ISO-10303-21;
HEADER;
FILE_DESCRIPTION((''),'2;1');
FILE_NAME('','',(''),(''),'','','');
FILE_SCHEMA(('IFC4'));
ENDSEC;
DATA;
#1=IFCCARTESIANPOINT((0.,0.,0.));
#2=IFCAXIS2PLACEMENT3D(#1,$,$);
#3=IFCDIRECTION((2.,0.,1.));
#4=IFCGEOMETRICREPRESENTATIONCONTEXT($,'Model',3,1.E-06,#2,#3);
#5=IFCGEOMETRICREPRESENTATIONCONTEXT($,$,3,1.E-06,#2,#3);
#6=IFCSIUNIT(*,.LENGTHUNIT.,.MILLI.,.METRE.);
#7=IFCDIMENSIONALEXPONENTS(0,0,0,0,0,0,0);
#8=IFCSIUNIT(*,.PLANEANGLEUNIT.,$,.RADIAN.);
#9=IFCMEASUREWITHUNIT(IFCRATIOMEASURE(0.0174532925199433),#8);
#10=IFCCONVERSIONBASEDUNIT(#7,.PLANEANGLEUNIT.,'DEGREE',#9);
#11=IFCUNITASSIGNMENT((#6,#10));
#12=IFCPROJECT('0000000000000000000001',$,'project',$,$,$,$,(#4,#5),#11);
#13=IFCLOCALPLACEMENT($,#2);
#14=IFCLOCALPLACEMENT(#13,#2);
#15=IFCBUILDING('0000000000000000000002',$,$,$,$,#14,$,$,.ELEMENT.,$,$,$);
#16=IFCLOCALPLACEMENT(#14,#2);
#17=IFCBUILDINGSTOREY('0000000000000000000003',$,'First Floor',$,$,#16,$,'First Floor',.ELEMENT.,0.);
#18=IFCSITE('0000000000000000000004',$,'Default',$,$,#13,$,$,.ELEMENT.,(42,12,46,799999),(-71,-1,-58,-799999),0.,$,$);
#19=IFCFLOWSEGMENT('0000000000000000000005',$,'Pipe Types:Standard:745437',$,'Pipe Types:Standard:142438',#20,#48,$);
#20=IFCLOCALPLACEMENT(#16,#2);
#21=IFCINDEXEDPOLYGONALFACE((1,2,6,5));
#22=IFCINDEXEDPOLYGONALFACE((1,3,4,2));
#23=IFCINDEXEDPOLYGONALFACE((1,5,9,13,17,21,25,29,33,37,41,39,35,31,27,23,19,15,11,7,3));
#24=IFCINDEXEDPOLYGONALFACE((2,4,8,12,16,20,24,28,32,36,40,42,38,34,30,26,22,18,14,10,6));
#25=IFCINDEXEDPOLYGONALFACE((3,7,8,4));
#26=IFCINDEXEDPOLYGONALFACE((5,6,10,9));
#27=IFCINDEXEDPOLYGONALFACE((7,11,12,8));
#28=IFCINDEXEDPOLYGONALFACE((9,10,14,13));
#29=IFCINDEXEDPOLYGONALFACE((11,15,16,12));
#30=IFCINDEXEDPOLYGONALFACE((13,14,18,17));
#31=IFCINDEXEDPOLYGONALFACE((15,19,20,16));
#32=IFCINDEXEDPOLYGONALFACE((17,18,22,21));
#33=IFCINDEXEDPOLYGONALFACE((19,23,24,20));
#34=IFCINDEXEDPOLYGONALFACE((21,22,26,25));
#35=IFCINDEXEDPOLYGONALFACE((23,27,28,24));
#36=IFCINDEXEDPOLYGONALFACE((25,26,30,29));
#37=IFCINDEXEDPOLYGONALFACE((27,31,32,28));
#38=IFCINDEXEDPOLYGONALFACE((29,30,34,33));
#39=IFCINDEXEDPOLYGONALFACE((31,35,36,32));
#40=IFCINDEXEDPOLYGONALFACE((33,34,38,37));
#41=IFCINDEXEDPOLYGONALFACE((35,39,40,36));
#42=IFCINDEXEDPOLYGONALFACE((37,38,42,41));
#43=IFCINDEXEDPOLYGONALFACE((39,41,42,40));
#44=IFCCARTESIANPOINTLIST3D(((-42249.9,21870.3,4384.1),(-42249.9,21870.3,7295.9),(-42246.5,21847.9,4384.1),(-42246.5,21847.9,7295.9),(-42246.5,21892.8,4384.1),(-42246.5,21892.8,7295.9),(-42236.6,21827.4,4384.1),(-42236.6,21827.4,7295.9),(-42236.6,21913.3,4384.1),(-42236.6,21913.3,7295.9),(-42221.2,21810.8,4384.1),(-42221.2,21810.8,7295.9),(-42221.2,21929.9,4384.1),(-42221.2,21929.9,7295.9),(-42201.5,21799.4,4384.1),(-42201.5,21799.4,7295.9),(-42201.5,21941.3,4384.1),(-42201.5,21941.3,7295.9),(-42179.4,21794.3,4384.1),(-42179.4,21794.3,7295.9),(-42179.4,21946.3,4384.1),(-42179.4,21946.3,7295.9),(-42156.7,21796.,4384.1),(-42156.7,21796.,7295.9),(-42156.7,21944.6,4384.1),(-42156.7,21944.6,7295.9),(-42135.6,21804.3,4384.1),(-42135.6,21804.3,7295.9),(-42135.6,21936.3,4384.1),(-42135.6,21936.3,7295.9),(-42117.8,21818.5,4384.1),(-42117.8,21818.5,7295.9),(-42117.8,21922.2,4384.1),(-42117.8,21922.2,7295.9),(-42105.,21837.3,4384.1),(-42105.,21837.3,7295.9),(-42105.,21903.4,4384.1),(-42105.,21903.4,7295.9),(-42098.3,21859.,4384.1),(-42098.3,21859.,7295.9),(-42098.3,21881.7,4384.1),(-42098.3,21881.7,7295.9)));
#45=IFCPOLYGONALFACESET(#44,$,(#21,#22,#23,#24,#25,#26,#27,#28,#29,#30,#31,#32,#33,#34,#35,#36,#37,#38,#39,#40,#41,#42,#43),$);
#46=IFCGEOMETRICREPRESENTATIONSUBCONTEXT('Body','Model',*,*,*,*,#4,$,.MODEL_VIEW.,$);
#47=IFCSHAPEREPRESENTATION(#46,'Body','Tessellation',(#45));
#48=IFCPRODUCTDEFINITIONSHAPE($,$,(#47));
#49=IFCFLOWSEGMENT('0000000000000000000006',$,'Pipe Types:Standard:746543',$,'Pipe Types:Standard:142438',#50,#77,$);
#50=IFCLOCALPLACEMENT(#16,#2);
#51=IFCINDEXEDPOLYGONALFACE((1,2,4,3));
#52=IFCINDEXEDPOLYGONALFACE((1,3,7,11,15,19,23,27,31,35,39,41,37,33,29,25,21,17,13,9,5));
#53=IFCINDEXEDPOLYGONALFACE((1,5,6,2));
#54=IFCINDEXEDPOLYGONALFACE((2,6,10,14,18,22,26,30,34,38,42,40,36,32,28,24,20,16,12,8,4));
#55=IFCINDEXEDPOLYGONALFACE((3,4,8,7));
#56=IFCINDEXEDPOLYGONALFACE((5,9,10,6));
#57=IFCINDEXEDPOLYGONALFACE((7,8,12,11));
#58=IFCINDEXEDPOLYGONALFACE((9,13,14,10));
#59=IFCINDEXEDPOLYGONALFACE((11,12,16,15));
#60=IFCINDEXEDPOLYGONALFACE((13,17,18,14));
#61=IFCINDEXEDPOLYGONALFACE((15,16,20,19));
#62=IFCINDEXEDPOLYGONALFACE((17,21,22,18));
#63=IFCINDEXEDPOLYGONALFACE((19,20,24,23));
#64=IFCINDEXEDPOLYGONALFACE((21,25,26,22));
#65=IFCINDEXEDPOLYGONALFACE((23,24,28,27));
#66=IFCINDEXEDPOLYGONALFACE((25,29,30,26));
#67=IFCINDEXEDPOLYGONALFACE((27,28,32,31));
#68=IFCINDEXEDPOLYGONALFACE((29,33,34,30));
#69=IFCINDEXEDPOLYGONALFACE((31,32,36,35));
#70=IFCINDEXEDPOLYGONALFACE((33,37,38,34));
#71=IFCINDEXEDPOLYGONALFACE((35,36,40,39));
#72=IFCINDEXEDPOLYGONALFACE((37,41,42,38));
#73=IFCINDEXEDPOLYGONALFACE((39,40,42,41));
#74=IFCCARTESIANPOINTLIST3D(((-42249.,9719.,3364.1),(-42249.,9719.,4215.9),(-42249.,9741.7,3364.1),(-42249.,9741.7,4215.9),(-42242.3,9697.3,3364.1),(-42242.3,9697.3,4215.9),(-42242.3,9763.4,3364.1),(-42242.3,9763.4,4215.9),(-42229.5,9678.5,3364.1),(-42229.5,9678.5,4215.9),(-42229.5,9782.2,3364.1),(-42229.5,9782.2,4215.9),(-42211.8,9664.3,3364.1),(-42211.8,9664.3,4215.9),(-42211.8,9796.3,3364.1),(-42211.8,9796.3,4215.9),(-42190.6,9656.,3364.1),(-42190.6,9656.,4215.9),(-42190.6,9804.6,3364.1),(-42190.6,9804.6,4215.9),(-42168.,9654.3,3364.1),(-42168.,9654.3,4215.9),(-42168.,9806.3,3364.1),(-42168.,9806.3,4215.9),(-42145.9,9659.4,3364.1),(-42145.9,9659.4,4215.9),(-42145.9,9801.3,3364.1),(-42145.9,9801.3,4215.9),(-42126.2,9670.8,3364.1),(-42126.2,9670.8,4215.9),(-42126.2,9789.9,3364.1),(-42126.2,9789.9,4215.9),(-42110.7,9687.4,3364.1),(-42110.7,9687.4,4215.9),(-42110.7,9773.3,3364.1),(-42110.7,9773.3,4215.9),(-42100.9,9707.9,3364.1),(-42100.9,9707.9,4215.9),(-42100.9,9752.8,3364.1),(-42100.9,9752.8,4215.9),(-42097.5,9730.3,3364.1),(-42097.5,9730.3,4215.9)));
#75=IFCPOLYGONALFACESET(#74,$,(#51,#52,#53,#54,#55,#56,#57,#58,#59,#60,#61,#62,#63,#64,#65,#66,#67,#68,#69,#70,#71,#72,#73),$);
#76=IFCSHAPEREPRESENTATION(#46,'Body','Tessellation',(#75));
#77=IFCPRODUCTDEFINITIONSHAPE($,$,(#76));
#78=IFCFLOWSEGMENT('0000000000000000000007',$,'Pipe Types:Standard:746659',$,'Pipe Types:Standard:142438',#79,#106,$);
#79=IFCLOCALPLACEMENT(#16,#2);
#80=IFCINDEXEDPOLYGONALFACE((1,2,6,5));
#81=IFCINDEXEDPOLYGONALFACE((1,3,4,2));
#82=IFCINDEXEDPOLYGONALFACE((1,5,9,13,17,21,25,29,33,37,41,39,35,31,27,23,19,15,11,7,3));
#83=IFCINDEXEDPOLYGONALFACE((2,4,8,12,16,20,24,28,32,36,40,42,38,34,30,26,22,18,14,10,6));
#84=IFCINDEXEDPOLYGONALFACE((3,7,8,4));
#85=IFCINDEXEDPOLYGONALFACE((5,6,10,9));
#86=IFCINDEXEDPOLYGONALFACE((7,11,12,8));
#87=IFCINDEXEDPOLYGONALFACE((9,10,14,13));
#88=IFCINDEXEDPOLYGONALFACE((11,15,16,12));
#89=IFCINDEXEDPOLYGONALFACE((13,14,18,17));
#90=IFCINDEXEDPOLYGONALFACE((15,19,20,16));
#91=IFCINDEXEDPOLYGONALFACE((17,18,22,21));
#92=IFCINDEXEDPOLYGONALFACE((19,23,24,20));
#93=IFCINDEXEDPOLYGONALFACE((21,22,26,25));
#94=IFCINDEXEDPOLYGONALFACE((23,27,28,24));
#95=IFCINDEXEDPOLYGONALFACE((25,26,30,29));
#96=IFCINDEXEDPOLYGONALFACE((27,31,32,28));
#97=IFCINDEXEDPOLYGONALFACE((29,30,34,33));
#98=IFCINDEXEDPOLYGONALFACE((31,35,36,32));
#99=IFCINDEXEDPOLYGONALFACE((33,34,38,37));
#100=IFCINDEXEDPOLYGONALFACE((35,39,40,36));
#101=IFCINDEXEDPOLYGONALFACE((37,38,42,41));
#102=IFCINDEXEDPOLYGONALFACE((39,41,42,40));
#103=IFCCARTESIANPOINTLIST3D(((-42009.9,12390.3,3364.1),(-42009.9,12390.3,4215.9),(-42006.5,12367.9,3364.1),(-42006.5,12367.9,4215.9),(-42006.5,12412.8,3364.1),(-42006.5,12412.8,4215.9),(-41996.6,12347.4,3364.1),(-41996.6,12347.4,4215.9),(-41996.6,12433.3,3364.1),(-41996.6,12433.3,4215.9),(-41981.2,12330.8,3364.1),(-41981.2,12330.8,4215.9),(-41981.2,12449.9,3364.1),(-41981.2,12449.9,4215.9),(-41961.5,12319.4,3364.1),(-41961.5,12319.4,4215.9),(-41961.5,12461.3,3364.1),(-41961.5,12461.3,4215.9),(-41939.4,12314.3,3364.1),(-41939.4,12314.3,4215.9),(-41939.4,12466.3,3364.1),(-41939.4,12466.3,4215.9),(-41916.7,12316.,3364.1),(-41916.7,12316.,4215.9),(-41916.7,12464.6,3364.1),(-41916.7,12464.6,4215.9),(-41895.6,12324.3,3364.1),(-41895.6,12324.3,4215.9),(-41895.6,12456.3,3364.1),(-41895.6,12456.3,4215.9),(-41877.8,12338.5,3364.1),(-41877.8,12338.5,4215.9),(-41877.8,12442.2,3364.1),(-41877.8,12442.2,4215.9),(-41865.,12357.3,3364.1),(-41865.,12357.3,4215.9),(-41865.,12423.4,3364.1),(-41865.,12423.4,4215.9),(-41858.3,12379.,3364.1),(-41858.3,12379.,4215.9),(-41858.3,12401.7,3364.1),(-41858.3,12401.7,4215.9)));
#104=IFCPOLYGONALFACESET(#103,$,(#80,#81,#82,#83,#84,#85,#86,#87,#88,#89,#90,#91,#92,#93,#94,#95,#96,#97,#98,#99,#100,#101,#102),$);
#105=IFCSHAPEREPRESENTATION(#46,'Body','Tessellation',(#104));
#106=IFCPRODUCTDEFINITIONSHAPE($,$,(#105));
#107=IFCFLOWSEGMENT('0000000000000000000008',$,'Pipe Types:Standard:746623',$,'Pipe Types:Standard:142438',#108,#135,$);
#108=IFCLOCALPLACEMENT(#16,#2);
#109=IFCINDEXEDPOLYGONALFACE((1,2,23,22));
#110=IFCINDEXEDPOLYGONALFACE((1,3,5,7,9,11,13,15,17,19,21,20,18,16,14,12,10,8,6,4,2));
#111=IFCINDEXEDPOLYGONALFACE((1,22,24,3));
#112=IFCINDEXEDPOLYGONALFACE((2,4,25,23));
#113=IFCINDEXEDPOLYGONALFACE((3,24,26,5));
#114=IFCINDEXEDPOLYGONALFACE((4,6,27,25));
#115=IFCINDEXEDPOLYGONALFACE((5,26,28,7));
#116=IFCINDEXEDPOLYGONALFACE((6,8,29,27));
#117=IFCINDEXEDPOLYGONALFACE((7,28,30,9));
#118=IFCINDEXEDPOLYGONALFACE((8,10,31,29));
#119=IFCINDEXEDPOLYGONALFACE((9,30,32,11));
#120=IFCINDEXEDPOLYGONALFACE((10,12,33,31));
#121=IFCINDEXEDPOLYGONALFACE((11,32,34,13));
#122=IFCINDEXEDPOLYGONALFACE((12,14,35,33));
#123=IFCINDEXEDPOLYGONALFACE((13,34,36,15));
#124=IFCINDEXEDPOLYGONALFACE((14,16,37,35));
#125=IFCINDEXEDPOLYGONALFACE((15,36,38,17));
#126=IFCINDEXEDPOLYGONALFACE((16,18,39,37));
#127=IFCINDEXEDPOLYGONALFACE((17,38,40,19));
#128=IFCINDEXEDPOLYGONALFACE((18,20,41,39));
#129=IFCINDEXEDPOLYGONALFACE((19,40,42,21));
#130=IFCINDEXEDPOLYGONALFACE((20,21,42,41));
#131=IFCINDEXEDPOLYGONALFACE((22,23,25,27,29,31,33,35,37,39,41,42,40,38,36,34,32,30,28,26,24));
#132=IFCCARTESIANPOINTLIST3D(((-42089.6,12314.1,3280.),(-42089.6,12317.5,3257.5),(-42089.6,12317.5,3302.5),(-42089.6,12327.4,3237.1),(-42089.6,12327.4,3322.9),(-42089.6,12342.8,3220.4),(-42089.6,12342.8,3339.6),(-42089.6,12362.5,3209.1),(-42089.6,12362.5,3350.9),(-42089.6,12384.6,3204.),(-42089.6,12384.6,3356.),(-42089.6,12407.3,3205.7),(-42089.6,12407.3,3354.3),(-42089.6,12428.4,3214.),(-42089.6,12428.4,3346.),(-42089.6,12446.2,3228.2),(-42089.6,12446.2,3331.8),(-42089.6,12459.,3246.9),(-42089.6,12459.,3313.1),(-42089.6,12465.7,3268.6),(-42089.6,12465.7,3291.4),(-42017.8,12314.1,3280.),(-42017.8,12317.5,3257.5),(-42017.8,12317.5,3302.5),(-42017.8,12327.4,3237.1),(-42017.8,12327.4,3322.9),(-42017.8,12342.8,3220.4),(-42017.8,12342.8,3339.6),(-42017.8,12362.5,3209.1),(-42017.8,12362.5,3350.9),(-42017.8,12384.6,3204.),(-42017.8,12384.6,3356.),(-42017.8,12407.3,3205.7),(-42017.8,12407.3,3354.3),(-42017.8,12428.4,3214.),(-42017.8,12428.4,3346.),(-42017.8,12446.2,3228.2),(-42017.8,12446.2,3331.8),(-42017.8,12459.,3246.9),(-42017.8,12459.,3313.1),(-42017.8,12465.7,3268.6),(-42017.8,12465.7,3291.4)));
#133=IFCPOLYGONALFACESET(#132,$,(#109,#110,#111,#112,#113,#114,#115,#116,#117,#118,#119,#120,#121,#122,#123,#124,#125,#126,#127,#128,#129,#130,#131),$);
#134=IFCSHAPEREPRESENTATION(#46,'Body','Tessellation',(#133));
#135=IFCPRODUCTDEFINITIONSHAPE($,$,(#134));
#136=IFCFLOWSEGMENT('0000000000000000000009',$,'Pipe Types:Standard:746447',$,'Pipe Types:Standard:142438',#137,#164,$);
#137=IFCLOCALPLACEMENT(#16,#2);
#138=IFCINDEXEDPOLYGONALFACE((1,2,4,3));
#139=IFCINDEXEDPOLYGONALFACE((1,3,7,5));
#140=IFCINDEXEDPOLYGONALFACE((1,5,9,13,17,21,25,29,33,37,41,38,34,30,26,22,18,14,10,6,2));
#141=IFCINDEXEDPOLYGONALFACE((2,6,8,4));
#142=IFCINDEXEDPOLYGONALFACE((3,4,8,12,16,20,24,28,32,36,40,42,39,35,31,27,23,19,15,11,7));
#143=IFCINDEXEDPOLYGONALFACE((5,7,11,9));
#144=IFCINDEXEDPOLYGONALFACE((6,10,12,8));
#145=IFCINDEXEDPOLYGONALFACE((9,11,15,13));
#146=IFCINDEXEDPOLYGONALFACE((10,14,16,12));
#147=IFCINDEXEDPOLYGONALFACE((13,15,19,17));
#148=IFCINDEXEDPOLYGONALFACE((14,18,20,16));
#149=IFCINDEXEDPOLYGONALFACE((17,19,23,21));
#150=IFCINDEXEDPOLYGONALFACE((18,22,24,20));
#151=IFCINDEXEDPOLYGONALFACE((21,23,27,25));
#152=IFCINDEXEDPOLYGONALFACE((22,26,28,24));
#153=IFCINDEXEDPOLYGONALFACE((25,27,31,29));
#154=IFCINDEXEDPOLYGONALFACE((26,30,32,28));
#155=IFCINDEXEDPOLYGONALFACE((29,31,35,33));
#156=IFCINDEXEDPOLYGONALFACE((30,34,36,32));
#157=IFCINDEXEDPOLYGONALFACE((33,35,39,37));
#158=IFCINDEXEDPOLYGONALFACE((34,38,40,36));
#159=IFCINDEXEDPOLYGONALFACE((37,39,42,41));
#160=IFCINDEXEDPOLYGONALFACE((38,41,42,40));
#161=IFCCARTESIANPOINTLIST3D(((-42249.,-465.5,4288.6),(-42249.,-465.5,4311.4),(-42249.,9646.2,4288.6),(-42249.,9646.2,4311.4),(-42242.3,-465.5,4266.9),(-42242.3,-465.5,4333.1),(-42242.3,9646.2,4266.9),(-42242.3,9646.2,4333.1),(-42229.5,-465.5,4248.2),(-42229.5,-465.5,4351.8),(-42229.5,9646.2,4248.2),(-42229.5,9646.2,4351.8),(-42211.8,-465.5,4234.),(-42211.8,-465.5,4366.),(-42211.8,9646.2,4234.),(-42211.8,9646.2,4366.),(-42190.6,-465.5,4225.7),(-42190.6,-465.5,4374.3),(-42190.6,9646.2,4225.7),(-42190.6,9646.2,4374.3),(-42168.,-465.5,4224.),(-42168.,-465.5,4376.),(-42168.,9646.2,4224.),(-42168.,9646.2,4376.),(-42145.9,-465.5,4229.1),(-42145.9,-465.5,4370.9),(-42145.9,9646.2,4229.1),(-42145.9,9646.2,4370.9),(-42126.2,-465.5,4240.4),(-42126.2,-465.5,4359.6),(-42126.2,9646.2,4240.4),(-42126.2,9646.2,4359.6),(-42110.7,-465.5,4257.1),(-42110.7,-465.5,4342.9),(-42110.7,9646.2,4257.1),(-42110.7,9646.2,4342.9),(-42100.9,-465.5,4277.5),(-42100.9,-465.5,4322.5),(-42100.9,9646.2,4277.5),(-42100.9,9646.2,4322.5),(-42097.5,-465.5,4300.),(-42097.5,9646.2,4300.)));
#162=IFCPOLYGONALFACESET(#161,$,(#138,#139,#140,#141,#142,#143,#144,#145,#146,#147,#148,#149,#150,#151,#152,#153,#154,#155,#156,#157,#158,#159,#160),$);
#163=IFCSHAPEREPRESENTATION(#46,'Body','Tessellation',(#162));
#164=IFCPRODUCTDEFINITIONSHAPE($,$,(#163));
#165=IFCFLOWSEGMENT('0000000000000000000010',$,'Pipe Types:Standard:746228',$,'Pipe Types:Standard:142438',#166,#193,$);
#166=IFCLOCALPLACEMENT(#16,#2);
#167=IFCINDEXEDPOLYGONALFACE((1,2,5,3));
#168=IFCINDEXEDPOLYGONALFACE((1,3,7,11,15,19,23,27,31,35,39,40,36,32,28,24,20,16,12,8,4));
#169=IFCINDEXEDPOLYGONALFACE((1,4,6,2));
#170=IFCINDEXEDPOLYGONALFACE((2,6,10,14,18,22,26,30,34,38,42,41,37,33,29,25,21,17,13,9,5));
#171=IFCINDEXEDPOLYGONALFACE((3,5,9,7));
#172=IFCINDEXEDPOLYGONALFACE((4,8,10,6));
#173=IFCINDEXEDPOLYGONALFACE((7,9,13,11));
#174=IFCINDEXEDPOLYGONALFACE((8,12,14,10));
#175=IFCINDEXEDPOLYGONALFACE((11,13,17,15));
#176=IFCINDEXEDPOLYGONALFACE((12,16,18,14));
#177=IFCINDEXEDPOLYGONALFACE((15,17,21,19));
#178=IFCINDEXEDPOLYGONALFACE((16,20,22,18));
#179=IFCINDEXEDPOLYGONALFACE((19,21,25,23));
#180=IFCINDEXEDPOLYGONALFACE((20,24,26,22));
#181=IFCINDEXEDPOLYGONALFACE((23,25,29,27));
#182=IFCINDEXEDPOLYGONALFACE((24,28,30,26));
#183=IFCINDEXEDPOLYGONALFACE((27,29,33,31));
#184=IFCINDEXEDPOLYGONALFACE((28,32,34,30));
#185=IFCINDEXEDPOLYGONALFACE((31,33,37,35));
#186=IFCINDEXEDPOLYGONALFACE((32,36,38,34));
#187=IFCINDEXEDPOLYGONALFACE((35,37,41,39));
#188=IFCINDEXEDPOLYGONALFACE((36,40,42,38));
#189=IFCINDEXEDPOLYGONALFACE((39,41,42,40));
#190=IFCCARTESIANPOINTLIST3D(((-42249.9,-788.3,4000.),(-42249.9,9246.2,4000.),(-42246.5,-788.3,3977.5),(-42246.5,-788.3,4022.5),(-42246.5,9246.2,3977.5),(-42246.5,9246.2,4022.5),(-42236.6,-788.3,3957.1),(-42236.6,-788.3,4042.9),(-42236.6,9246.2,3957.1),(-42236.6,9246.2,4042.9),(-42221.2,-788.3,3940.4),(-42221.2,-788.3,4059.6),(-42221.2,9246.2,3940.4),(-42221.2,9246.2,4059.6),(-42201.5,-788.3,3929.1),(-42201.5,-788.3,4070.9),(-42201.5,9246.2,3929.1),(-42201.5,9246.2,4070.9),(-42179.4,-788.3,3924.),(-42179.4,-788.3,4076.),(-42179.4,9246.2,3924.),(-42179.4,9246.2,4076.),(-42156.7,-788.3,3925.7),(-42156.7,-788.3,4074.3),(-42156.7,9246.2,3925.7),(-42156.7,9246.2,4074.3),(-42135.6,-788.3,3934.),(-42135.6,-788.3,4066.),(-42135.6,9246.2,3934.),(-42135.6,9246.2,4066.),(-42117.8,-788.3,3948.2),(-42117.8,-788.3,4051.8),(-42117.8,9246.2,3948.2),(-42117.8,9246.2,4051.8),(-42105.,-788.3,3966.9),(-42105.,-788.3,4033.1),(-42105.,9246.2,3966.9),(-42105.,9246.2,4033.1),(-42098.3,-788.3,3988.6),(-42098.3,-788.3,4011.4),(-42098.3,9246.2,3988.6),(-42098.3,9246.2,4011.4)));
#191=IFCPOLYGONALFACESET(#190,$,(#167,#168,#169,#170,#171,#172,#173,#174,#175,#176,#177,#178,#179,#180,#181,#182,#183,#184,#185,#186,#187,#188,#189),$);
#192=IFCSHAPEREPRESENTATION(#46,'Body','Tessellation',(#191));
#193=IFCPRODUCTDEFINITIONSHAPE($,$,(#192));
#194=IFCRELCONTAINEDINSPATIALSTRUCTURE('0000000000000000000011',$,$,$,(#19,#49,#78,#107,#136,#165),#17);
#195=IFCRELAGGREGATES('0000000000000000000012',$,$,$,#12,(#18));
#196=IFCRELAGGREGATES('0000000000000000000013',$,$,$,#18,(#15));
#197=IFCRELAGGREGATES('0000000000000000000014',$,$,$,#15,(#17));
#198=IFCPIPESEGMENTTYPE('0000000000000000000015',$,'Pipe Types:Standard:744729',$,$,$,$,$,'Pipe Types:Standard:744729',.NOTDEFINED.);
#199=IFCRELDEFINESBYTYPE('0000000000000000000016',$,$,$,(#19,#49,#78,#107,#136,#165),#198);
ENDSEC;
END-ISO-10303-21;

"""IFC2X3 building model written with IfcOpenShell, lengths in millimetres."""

from ifc_helpers import new_model, entity, si_unit, converted_unit, direction, frame, frame_2d, origin, origin_2d_with_axis, place, context, subcontext, project, spatial, circle, extrude, type_object, element, save


model = new_model("IFC2X3")

# Units and contexts
model_context = context("Model", 3, precision=1e-06, world=origin(), true_north=direction((2.0, 0.0, 1.0)))
context_of_model = context(None, 3, precision=1e-06, world=origin(), true_north=direction((2.0, 0.0, 1.0)))
body_context = subcontext(model_context, "Body", "Model", "MODEL_VIEW")
ifc_project = project(units=[si_unit("LENGTHUNIT", "METRE", prefix="MILLI"), converted_unit("PLANEANGLEUNIT", "DEGREE", entity("IfcRatioMeasure", 0.0174532925199433), si_unit("PLANEANGLEUNIT", "RADIAN"), dimensions=[0, 0, 0, 0, 0, 0, 0])], contexts=[model_context, context_of_model])

# Site, building, storey
site_placement = place(None, origin())
site = spatial("IfcSite", under=ifc_project, at=site_placement, Name="Default", CompositionType="ELEMENT", RefLatitude=(42, 12, 46, 799999), RefLongitude=(-71, -1, -58, -799999), RefElevation=0.0)
building_placement = place(site_placement, origin())
building = spatial("IfcBuilding", under=site, at=building_placement, CompositionType="ELEMENT")
storey_placement = place(building_placement, origin())
storey = spatial("IfcBuildingStorey", under=building, at=storey_placement, Name="First Floor", LongName="First Floor", CompositionType="ELEMENT", Elevation=0.0)

# Flow segments
pipe_segment_type = type_object("IfcPipeSegmentType", Name="Pipe Types:Standard:744729", ElementType="Pipe Types:Standard:744729", PredefinedType="NOTDEFINED")
flow_segment_1_placement = place(storey_placement, origin())
element("IfcFlowSegment", 1, at=flow_segment_1_placement, inside=storey, type_object=pipe_segment_type, Name="Pipe Types:Standard:745437", ObjectType="Pipe Types:Standard:142438", context=body_context, shape_type="SweptSolid", body=[
    extrude(circle(Radius=76.2, at=origin_2d_with_axis()), frame((-42173.7, 21870.3, 4384.1), z_axis=(0.0, 0.0, 1.0), x_axis=(-1.0, 0.0, 0.0)), (0.0, 0.0, 1.0), 2911.7),
])
flow_segment_2_placement = place(storey_placement, origin())
element("IfcFlowSegment", 2, at=flow_segment_2_placement, inside=storey, type_object=pipe_segment_type, Name="Pipe Types:Standard:746543", ObjectType="Pipe Types:Standard:142438", context=body_context, shape_type="SweptSolid", body=[
    extrude(circle(Radius=76.2, at=frame_2d((0.0, 0.0), x_axis=(1.0, 0.0))), frame((-42173.7, 9730.3, 3364.1)), (0.0, 0.0, 1.0), 851.7),
])
flow_segment_3_placement = place(storey_placement, origin())
element("IfcFlowSegment", 3, at=flow_segment_3_placement, inside=storey, type_object=pipe_segment_type, Name="Pipe Types:Standard:746659", ObjectType="Pipe Types:Standard:142438", context=body_context, shape_type="SweptSolid", body=[
    extrude(circle(Radius=76.2, at=origin_2d_with_axis()), frame((-41933.7, 12390.3, 3364.1), z_axis=(0.0, 0.0, 1.0), x_axis=(-1.0, 0.0, 0.0)), (0.0, 0.0, 1.0), 851.7),
])
flow_segment_4_placement = place(storey_placement, origin())
element("IfcFlowSegment", 4, at=flow_segment_4_placement, inside=storey, type_object=pipe_segment_type, Name="Pipe Types:Standard:746623", ObjectType="Pipe Types:Standard:142438", context=body_context, shape_type="SweptSolid", body=[
    extrude(circle(Radius=76.2, at=origin_2d_with_axis()), frame((-42089.6, 12390.3, 3280.0), z_axis=(1.0, 0.0, 0.0), x_axis=(0.0, -1.0, 0.0)), (0.0, 0.0, 1.0), 71.7),
])
flow_segment_5_placement = place(storey_placement, origin())
element("IfcFlowSegment", 5, at=flow_segment_5_placement, inside=storey, type_object=pipe_segment_type, Name="Pipe Types:Standard:746447", ObjectType="Pipe Types:Standard:142438", context=body_context, shape_type="SweptSolid", body=[
    extrude(circle(Radius=76.2, at=frame_2d((0.0, 0.0), x_axis=(1.0, 0.0))), frame((-42173.7, -465.5, 4300.0), z_axis=(0.0, 1.0, 0.0), x_axis=(1.0, 0.0, 0.0)), (0.0, 0.0, 1.0), 10111.7),
])
flow_segment_6_placement = place(storey_placement, origin())
element("IfcFlowSegment", 6, at=flow_segment_6_placement, inside=storey, type_object=pipe_segment_type, Name="Pipe Types:Standard:746228", ObjectType="Pipe Types:Standard:142438", context=body_context, shape_type="SweptSolid", body=[
    extrude(circle(Radius=76.2, at=origin_2d_with_axis()), frame((-42173.7, -788.3, 4000.0), z_axis=(0.0, 1.0, 0.0), x_axis=(-1.0, 0.0, 0.0)), (0.0, 0.0, 1.0), 10034.5),
])

save(model, "model.ifc")
